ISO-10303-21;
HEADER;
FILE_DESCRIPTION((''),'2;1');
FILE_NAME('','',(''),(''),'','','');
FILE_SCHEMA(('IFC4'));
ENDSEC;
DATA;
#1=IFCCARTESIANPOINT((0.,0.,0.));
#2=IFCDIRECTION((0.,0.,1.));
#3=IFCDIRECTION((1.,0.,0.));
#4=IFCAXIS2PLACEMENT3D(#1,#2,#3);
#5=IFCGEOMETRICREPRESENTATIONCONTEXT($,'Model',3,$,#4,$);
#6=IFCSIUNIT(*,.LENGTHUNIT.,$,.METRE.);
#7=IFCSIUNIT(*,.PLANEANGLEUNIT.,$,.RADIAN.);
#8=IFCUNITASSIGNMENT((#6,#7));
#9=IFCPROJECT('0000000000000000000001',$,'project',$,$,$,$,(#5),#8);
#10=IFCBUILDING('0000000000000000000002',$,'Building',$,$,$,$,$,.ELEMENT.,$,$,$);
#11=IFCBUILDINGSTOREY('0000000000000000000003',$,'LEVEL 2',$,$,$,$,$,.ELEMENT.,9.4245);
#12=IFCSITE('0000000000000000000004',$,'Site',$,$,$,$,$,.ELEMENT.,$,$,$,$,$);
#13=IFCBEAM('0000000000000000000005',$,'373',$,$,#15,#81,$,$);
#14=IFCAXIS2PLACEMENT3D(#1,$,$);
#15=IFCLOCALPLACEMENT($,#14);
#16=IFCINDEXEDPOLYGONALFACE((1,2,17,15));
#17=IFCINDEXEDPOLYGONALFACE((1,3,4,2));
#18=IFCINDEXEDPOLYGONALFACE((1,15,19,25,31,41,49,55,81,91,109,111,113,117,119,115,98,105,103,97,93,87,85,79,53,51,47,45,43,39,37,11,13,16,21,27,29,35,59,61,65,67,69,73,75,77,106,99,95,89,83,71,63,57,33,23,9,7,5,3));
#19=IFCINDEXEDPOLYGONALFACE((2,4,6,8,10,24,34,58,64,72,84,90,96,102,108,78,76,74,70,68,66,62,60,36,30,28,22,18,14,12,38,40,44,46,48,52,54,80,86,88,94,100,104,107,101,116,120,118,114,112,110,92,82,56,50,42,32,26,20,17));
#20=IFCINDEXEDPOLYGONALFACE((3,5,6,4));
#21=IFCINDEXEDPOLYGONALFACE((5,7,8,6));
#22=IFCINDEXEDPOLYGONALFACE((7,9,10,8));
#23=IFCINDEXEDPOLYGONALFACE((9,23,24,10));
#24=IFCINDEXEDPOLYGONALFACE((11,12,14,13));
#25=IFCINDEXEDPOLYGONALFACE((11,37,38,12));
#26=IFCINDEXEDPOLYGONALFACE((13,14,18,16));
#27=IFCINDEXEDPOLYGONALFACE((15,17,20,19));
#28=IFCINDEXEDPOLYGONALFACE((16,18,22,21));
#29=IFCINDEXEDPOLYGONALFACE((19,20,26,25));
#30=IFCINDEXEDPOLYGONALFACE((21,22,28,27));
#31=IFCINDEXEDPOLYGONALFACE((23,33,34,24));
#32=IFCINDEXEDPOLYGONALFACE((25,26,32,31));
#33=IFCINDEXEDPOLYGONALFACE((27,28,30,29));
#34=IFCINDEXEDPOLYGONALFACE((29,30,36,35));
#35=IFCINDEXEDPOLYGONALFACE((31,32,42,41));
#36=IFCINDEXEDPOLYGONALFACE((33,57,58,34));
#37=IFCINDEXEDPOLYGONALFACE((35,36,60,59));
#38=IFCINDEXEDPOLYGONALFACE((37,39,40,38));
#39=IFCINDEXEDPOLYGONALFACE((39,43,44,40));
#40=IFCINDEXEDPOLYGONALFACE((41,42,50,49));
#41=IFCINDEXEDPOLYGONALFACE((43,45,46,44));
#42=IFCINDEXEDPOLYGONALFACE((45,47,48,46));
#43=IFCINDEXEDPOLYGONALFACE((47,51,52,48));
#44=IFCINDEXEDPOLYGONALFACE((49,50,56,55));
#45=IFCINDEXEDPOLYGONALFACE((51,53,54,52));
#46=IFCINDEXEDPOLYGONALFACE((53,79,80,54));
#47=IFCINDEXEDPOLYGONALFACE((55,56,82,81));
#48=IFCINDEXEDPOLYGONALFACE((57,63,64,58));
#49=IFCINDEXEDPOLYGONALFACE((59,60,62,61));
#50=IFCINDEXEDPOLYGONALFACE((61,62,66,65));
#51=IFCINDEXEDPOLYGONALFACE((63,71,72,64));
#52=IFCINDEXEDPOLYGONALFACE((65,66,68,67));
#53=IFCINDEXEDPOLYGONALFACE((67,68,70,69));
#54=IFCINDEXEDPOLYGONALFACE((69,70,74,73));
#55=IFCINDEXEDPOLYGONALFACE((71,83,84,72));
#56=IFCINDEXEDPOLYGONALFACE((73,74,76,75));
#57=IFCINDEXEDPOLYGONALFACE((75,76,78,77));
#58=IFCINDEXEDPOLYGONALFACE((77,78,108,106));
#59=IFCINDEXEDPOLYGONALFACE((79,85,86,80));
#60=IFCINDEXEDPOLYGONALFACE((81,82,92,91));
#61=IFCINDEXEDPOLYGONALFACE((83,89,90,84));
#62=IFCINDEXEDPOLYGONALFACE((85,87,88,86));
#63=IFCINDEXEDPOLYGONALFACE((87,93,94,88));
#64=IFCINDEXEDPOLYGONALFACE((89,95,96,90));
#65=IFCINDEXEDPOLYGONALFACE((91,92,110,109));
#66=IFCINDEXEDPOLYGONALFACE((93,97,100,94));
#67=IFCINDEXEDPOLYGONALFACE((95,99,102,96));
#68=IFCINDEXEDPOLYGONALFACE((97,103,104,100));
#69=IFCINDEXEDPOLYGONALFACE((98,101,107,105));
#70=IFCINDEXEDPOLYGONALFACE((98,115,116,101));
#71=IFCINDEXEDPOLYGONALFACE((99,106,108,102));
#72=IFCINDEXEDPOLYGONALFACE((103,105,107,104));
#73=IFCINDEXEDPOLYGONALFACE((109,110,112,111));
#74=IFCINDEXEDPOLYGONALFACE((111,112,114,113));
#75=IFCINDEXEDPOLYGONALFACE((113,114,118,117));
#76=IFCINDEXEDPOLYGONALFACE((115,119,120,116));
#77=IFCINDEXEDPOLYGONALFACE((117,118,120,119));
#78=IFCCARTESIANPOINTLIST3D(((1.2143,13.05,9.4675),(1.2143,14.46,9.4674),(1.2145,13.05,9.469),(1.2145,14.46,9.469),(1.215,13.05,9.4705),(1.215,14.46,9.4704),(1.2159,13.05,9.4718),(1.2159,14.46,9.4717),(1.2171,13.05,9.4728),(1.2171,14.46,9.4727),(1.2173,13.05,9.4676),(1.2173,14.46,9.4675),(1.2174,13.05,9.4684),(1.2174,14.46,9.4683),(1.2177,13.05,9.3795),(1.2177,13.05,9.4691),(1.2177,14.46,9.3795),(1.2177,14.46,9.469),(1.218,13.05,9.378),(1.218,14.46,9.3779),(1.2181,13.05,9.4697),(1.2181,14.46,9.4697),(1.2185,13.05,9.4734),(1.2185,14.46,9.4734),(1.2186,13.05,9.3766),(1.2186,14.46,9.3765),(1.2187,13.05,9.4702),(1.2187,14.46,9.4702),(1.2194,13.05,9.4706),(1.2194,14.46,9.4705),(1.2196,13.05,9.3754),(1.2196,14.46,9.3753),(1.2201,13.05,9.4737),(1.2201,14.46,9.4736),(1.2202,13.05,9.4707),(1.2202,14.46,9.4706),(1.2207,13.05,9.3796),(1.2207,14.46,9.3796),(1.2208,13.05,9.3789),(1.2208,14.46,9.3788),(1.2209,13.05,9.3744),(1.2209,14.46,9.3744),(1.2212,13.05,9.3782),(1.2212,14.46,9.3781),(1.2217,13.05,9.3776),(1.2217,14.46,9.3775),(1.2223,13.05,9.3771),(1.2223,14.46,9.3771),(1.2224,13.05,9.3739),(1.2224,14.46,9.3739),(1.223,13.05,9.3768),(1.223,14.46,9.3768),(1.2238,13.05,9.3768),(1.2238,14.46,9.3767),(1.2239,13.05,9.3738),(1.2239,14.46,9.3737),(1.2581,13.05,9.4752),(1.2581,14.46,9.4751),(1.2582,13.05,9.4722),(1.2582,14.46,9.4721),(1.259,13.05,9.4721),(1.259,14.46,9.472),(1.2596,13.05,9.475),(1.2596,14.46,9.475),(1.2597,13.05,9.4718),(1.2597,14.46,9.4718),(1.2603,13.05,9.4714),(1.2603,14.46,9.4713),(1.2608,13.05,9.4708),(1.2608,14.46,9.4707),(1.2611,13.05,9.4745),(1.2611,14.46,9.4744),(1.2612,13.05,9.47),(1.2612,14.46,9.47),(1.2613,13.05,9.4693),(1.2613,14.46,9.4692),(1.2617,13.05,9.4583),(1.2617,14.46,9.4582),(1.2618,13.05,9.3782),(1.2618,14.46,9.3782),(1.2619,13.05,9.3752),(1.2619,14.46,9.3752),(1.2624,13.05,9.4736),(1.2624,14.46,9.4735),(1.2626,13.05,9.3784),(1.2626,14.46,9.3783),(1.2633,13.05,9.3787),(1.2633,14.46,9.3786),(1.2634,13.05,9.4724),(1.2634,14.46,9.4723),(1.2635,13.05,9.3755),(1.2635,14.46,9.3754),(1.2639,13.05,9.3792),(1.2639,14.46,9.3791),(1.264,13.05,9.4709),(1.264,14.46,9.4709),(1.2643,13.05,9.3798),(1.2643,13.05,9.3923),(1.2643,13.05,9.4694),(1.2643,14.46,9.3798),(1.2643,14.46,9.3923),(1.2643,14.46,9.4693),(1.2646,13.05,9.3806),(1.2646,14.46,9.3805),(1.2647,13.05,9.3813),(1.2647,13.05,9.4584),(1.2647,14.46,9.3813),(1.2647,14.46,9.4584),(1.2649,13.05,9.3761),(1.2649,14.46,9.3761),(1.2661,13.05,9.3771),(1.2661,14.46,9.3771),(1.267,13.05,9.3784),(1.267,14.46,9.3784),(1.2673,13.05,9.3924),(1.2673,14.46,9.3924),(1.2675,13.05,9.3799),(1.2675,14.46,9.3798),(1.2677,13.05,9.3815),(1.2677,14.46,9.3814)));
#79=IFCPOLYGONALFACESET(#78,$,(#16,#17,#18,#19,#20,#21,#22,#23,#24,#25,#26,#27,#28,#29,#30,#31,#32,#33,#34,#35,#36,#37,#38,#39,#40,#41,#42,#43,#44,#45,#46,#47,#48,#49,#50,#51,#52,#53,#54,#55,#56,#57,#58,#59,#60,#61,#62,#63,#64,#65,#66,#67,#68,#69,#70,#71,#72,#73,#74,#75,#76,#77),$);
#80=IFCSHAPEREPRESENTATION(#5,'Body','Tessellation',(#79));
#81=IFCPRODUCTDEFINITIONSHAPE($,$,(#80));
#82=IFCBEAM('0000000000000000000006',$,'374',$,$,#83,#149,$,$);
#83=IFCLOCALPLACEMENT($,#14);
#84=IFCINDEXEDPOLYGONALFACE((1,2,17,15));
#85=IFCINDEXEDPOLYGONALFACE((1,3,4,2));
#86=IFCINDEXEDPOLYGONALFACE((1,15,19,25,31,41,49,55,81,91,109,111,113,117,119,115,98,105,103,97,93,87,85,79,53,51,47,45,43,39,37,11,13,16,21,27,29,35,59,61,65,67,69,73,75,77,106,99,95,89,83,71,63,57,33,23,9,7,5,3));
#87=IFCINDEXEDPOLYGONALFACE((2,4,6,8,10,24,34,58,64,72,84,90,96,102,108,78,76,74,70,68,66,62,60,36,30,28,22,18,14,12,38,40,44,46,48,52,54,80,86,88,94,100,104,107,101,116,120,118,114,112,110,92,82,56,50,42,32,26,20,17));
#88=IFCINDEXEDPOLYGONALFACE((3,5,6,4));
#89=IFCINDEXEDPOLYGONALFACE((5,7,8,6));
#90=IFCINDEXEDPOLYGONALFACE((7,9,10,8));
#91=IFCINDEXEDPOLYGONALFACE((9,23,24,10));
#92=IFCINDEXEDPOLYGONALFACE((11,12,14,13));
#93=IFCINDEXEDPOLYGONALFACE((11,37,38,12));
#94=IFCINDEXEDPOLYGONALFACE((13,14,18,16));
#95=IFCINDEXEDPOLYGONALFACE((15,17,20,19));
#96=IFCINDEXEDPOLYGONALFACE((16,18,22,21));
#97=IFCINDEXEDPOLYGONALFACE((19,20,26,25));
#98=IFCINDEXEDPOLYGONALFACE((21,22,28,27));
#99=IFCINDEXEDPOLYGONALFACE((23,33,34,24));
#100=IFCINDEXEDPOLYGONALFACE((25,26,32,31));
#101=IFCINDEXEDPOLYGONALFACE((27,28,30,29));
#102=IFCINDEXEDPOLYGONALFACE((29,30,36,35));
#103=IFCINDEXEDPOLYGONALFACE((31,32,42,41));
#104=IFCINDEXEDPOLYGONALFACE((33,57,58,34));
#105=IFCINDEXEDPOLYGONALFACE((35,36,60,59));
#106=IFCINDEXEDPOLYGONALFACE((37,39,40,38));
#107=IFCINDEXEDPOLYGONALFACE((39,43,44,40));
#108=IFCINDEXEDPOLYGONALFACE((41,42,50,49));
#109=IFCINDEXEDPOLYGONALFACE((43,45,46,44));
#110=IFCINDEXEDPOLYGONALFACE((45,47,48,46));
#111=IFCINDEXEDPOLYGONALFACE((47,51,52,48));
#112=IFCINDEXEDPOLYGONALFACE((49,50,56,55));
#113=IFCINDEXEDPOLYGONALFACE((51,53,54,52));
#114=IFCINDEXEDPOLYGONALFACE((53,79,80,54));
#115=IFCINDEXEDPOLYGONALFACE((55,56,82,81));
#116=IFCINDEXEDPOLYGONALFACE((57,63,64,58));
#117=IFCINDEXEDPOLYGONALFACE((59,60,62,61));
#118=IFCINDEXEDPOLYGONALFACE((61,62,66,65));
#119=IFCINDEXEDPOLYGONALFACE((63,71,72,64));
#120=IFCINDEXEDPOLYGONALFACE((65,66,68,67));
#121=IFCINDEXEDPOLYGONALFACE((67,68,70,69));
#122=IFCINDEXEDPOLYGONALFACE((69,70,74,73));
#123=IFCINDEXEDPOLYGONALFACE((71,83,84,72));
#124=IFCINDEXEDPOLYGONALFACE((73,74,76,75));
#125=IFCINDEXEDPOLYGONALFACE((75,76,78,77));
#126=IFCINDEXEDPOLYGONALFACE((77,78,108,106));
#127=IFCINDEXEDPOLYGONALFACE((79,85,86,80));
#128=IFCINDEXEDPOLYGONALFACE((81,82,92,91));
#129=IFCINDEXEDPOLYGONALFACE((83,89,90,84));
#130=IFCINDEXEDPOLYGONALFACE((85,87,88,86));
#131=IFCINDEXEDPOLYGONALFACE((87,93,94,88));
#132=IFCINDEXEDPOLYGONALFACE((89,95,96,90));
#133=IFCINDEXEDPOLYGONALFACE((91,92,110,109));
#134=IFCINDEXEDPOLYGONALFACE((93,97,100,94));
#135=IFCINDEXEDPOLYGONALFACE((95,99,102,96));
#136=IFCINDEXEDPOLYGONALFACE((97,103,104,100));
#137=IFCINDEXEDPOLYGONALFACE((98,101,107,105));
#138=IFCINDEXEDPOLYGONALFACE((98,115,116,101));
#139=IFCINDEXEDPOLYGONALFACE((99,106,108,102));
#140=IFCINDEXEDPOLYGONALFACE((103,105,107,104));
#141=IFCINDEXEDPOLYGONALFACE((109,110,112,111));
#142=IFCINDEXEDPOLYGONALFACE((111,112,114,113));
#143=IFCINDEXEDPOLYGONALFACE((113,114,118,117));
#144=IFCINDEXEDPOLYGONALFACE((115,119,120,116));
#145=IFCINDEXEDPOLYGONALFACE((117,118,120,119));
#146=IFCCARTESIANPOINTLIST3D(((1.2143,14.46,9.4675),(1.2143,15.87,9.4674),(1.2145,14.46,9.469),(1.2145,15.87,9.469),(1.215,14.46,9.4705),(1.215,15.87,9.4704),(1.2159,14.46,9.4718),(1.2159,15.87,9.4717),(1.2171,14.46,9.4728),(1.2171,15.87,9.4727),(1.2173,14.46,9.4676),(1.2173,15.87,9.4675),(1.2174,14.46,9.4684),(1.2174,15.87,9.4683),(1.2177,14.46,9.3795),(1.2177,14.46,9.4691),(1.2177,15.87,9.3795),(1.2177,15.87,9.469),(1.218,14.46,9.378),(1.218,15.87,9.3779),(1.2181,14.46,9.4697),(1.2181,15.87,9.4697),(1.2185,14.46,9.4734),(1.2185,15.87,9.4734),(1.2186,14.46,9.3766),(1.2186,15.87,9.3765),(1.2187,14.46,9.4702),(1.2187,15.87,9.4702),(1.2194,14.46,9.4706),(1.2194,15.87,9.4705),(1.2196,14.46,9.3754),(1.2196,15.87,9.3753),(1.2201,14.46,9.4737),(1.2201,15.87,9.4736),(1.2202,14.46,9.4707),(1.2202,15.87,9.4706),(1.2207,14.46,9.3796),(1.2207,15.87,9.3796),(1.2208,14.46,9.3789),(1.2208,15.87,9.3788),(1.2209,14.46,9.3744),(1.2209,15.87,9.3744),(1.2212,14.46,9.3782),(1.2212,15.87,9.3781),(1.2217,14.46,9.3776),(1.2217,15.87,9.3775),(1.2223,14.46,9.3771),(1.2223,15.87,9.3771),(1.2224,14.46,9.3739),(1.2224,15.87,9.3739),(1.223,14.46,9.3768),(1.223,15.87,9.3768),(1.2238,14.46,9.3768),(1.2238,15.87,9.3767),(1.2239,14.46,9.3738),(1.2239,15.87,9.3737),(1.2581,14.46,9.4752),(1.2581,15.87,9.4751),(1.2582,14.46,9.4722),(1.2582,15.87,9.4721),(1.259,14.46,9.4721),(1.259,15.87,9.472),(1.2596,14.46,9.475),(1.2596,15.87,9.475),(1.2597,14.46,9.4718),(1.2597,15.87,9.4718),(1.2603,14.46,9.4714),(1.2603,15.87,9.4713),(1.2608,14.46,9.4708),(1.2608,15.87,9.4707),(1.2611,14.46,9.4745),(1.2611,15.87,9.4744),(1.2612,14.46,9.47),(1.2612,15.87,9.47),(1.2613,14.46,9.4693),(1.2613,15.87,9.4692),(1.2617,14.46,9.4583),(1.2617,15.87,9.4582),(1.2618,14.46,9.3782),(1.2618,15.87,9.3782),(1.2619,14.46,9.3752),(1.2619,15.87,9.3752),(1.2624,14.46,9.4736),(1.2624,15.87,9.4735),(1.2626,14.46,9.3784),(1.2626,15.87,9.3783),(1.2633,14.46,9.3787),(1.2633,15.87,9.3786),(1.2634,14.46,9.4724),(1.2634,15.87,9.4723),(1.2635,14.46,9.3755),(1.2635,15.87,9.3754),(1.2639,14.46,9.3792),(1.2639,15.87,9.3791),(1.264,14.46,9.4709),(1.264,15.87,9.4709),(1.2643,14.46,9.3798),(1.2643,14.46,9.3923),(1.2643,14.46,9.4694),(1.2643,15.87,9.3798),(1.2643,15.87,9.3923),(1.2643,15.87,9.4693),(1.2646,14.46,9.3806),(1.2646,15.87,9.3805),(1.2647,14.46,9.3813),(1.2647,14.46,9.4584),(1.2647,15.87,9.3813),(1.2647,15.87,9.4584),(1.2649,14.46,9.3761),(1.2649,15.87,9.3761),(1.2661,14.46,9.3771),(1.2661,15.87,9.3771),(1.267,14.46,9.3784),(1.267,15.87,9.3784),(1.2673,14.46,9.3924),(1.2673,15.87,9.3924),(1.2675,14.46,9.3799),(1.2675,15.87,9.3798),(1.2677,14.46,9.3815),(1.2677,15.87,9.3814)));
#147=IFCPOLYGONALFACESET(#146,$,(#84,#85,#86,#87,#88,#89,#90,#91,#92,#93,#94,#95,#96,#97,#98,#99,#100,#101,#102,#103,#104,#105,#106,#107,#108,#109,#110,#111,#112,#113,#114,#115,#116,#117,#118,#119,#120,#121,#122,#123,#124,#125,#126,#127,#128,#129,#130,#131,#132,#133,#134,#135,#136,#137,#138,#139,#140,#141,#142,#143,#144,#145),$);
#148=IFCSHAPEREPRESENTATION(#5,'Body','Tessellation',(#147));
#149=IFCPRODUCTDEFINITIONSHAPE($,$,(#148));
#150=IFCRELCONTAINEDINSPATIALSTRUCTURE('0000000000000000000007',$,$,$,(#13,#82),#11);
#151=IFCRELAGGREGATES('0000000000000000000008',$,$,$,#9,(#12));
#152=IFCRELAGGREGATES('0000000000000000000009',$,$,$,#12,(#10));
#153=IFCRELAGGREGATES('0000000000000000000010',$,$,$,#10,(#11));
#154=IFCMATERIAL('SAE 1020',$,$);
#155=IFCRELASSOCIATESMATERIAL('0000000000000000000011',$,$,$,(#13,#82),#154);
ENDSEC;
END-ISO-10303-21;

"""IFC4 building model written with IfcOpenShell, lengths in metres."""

from ifc_helpers import new_model, si_unit, frame, origin_with_axes, origin_2d_with_axis, place, context, project, spatial, c_section, extrude, material, material_profile, profile_set, profile_usage, element, save


model = new_model("IFC4")

# Units and contexts
model_context = context("Model", 3, world=origin_with_axes())
ifc_project = project(units=[si_unit("LENGTHUNIT", "METRE"), si_unit("PLANEANGLEUNIT", "RADIAN")], contexts=[model_context])

# Site, building, storey
site = spatial("IfcSite", under=ifc_project, Name="Site", CompositionType="ELEMENT")
building = spatial("IfcBuilding", under=site, Name="Building", CompositionType="ELEMENT")
storey = spatial("IfcBuildingStorey", under=building, Name="LEVEL 2", CompositionType="ELEMENT", Elevation=9.4245)

# Beams
ifc_material = material(Name="SAE 1020")
ifc_material_profile_1 = material_profile(ifc_material, c_section(Depth=0.1, Width=0.05, WallThickness=0.003, Girth=0.017, InternalFilletRadius=0.003, at=origin_2d_with_axis()))
ifc_profile_set_1 = profile_set([ifc_material_profile_1])
ifc_profile_usage_1 = profile_usage(ifc_profile_set_1, cardinal=10)
beam_1_placement = place(None, frame((1.241, 13.05, 9.4245), z_axis=(0.0, 1.0, -0.00003), x_axis=(0.999256, 0.000001, 0.038562)))
element("IfcBeam", 1, at=beam_1_placement, inside=storey, material=ifc_profile_usage_1, Name="373", context=model_context, shape_type="SweptSolid", body=[
    extrude(c_section(Depth=0.1, Width=0.05, WallThickness=0.003, Girth=0.017, InternalFilletRadius=0.003, at=origin_2d_with_axis()), origin_with_axes(), (0.0, 0.0, 1.0), 1.41),
])
ifc_material_profile_2 = material_profile(ifc_material, c_section(Depth=0.1, Width=0.05, WallThickness=0.003, Girth=0.017, InternalFilletRadius=0.003, at=origin_2d_with_axis()))
ifc_profile_set_2 = profile_set([ifc_material_profile_2])
ifc_profile_usage_2 = profile_usage(ifc_profile_set_2, cardinal=10)
beam_2_placement = place(None, frame((1.241, 14.46, 9.4245), z_axis=(0.0, 1.0, -0.00003), x_axis=(0.999256, 0.000001, 0.038562)))
element("IfcBeam", 2, at=beam_2_placement, inside=storey, material=ifc_profile_usage_2, Name="374", context=model_context, shape_type="SweptSolid", body=[
    extrude(c_section(Depth=0.1, Width=0.05, WallThickness=0.003, Girth=0.017, InternalFilletRadius=0.003, at=origin_2d_with_axis()), origin_with_axes(), (0.0, 0.0, 1.0), 1.41),
])

save(model, "model.ifc")
